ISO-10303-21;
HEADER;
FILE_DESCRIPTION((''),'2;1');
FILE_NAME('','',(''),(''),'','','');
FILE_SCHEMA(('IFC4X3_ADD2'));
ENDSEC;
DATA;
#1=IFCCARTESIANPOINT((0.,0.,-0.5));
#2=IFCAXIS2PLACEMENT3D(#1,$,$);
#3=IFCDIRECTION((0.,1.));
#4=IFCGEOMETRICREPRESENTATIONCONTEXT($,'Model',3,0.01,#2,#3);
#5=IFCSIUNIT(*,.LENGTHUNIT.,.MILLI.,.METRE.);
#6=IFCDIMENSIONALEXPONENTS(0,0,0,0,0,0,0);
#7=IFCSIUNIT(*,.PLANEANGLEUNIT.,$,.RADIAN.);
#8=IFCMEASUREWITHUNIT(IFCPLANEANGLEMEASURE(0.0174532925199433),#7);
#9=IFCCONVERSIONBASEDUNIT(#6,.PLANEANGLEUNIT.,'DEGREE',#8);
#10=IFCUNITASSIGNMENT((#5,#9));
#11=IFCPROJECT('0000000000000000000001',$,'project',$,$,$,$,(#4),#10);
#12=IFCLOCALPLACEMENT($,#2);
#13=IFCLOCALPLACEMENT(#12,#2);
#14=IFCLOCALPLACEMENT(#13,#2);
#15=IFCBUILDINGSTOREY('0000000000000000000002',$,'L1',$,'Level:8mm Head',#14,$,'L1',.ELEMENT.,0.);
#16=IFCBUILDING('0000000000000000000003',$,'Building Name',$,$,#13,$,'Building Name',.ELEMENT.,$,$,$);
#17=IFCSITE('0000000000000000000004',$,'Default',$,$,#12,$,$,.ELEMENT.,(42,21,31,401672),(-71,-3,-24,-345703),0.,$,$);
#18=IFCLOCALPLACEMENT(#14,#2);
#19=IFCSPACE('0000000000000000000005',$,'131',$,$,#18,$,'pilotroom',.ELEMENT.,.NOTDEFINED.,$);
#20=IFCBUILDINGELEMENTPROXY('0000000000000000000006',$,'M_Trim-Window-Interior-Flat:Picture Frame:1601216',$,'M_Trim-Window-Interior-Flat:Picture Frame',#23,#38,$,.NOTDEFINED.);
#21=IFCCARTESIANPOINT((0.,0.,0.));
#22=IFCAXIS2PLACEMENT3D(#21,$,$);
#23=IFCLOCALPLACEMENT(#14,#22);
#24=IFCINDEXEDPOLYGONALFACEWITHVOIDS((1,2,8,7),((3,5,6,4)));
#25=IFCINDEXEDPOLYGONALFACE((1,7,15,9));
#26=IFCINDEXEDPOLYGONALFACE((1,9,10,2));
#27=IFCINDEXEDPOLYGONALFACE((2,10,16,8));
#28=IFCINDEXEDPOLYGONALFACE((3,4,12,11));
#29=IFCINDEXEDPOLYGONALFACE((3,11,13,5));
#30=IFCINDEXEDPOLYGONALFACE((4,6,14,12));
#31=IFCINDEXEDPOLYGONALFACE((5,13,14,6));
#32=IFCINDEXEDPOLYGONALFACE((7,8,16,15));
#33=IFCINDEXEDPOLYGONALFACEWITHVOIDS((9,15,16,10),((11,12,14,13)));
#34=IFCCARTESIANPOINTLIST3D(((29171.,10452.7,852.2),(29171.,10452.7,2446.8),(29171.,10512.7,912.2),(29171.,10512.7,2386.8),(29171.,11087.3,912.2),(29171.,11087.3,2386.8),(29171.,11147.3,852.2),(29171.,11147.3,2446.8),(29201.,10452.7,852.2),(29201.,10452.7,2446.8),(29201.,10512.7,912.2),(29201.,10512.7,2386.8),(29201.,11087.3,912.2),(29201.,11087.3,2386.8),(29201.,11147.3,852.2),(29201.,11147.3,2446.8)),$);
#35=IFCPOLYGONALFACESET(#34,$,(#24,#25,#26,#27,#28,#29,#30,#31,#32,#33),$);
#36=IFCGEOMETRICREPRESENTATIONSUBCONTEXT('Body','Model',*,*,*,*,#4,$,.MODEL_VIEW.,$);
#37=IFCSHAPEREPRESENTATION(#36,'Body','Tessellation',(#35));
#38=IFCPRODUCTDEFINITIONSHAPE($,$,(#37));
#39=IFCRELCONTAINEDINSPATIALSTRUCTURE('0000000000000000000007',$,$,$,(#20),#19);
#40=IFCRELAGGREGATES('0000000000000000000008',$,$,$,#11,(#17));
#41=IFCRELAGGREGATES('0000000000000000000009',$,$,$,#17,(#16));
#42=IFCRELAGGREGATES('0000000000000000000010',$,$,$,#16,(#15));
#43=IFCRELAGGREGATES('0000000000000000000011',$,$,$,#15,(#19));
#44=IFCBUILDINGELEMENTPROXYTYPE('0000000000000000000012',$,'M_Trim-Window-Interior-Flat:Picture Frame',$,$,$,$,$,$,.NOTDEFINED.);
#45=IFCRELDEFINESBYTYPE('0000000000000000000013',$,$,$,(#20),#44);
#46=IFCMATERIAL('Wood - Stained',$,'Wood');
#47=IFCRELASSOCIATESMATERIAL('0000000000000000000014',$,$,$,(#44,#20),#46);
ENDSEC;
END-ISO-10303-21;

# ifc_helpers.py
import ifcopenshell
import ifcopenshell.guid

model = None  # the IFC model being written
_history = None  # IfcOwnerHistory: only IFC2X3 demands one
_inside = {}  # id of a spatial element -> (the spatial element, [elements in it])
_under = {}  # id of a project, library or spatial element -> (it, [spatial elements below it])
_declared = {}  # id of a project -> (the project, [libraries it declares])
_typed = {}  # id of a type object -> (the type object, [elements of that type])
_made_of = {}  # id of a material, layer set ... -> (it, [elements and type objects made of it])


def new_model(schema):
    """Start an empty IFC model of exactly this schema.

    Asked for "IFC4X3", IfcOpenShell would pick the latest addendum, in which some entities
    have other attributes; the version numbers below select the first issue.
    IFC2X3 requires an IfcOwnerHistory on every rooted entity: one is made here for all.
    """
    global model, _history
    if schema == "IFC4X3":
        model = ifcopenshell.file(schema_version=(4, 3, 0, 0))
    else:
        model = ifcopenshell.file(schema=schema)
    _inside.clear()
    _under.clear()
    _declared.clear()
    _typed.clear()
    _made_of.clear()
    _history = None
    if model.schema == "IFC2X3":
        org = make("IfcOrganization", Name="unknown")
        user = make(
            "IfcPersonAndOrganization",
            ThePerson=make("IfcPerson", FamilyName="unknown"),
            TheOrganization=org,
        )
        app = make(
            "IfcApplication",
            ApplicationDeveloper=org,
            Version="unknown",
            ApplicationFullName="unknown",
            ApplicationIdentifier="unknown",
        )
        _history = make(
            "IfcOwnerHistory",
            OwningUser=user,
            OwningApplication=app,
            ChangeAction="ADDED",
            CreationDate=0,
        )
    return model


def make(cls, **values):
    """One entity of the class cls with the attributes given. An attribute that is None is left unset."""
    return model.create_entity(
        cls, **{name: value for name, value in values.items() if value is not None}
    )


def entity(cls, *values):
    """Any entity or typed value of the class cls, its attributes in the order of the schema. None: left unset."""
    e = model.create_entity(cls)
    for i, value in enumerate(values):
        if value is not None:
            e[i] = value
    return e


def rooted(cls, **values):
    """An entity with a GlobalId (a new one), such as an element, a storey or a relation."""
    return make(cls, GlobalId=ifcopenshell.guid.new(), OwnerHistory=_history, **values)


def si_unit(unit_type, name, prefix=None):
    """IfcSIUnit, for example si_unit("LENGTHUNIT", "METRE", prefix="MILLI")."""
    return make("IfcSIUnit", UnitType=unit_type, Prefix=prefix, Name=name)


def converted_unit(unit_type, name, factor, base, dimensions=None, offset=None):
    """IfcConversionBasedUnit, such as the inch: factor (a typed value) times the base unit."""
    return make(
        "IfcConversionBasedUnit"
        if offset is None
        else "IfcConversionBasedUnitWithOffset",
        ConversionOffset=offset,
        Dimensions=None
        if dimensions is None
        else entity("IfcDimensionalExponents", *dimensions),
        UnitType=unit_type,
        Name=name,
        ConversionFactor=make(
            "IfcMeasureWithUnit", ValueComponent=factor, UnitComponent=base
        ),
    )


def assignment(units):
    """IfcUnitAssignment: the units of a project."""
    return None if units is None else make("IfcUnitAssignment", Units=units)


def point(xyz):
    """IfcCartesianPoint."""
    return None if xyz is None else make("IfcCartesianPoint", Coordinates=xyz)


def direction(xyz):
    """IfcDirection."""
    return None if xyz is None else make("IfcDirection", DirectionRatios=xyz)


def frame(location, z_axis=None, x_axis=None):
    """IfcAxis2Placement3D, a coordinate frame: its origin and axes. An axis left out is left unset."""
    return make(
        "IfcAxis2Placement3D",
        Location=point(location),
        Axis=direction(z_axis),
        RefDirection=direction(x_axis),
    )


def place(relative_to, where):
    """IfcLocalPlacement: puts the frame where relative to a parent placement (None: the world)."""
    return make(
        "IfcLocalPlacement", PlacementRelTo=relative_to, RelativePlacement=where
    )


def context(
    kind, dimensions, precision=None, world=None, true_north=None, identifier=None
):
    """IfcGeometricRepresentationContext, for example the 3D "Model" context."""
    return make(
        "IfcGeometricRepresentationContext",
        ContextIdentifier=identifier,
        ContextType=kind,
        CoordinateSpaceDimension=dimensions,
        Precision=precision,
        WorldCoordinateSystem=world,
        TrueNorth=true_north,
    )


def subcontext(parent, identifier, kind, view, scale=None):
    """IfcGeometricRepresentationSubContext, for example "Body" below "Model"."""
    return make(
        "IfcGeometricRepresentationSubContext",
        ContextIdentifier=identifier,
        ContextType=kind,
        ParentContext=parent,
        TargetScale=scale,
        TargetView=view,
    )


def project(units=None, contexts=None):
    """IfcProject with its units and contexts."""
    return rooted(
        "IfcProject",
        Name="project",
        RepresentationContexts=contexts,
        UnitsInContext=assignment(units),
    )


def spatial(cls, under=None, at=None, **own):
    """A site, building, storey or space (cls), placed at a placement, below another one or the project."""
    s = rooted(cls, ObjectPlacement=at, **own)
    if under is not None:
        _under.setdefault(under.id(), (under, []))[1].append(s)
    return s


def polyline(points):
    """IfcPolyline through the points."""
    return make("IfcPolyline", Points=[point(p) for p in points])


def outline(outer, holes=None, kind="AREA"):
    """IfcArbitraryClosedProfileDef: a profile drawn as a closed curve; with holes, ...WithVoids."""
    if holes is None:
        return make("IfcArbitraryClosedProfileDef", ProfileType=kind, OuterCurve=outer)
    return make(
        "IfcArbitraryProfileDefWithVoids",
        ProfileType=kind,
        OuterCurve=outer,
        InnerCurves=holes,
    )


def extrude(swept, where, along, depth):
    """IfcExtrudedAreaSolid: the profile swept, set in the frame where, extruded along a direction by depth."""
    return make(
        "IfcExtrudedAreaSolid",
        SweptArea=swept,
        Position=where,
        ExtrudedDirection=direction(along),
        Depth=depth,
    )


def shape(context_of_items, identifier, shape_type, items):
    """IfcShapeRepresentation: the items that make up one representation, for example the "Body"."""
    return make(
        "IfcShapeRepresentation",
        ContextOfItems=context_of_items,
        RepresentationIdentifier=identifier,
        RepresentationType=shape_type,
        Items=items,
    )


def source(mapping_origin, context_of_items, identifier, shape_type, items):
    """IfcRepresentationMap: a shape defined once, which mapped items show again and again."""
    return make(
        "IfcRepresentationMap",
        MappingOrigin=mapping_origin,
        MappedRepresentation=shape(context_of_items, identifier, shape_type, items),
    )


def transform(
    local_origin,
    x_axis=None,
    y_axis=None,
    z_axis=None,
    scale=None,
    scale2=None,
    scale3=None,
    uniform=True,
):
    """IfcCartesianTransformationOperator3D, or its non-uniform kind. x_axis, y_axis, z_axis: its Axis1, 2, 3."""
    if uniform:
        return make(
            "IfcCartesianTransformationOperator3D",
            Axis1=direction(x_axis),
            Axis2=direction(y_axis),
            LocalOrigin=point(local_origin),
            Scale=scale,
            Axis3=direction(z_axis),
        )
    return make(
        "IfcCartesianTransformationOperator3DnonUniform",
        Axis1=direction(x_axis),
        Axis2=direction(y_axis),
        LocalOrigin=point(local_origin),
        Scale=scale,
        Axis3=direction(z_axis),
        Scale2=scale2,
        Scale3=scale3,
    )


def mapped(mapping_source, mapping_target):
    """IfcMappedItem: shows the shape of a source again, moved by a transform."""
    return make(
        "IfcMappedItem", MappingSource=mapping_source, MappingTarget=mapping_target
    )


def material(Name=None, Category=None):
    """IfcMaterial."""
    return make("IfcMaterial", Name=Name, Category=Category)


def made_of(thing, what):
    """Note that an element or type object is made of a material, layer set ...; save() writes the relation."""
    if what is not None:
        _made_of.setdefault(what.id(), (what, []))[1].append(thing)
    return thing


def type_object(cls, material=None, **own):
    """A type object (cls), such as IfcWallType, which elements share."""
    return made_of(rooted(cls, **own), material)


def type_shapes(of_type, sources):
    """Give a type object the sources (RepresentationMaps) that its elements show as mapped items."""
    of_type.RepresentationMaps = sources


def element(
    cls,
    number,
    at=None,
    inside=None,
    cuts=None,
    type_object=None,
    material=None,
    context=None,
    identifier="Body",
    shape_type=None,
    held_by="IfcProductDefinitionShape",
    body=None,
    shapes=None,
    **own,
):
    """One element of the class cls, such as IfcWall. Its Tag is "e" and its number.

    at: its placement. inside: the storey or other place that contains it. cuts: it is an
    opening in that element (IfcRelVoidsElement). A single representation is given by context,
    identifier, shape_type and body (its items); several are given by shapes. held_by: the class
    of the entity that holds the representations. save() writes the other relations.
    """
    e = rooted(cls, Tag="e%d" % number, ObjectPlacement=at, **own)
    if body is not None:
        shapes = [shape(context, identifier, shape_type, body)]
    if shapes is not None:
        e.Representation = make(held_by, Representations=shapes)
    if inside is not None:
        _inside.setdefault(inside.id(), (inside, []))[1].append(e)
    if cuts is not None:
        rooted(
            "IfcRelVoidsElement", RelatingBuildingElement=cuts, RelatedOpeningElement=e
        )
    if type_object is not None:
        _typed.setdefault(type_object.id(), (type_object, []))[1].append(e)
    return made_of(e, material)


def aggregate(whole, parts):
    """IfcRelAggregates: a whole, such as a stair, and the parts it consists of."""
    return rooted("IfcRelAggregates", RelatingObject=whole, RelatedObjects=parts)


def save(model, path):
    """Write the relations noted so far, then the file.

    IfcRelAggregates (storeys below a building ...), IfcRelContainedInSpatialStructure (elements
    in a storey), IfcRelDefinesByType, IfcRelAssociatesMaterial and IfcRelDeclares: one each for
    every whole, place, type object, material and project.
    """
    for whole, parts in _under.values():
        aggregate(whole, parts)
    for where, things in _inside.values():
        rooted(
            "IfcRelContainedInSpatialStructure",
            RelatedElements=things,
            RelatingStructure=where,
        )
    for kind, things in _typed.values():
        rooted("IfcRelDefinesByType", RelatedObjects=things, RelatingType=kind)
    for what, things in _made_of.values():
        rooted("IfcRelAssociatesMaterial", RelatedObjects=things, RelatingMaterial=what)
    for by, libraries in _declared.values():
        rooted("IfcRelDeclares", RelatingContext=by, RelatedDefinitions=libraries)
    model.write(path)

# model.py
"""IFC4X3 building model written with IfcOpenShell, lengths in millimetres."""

from ifc_helpers import new_model, entity, si_unit, converted_unit, direction, frame, place, context, subcontext, project, spatial, polyline, outline, extrude, source, transform, mapped, material, type_object, type_shapes, element, save


model = new_model("IFC4X3")

# Units and contexts
model_context = context("Model", 3, precision=0.01, world=frame((0.0, 0.0, -0.5)), true_north=direction((0.0, 1.0)))
body_context = subcontext(model_context, "Body", "Model", "MODEL_VIEW")
ifc_project = project(units=[si_unit("LENGTHUNIT", "METRE", prefix="MILLI"), converted_unit("PLANEANGLEUNIT", "DEGREE", entity("IfcPlaneAngleMeasure", 0.0174532925199433), si_unit("PLANEANGLEUNIT", "RADIAN"), dimensions=[0, 0, 0, 0, 0, 0, 0])], contexts=[model_context])

# Site, building, storey
site_placement = place(None, frame((0.0, 0.0, -0.5)))
site = spatial("IfcSite", under=ifc_project, at=site_placement, Name="Default", CompositionType="ELEMENT", RefLatitude=(42, 21, 31, 401672), RefLongitude=(-71, -3, -24, -345703), RefElevation=0.0)
building_placement = place(site_placement, frame((0.0, 0.0, -0.5)))
building = spatial("IfcBuilding", under=site, at=building_placement, Name="Building Name", LongName="Building Name", CompositionType="ELEMENT")
storey_placement = place(building_placement, frame((0.0, 0.0, -0.5)))
storey = spatial("IfcBuildingStorey", under=building, at=storey_placement, Name="L1", ObjectType="Level:8mm Head", LongName="L1", CompositionType="ELEMENT", Elevation=0.0)

# Shared definitions
ifc_material_1 = material(Name="Wood - Stained", Category="Wood")

# Shared definitions
space_placement = place(storey_placement, frame((0.0, 0.0, -0.5)))
space = spatial("IfcSpace", under=storey, at=space_placement, Name="131", LongName="pilotroom", CompositionType="ELEMENT", PredefinedType="NOTDEFINED")

# Building element proxy
building_element_proxy_type_1 = type_object("IfcBuildingElementProxyType", Name="M_Trim-Window-Interior-Flat:Picture Frame", PredefinedType="NOTDEFINED", material=ifc_material_1)
shared_shape_1 = source(frame((0.0, 0.0, -0.5)), body_context, "Body", "SweptSolid", [
    extrude(outline(polyline([(-347.3, -797.3), (347.3, -797.3), (347.3, 797.3), (-347.3, 797.3), (-347.3, -797.3)]), holes=[polyline([(-287.3, -737.3), (-287.3, 737.3), (287.3, 737.3), (287.3, -737.3), (-287.3, -737.3)])]), frame((0.0, -750.0, 0.0), z_axis=(0.0, 0.0, 1.0), x_axis=(-1.0, 0.0, 0.0)), (0.0, 0.0, 1.0), 30.0),
])
type_shapes(building_element_proxy_type_1, [shared_shape_1])
proxy_1_placement = place(space_placement, frame((29200.0, 10800.0, 2400.0), z_axis=(-1.0, 0.0, 0.0), x_axis=(0.0, -1.0, 0.0)))
element("IfcBuildingElementProxy", 1, at=proxy_1_placement, inside=space, type_object=building_element_proxy_type_1, material=ifc_material_1, Name="M_Trim-Window-Interior-Flat:Picture Frame:1601216", ObjectType="M_Trim-Window-Interior-Flat:Picture Frame", PredefinedType="NOTDEFINED", context=body_context, shape_type="MappedRepresentation", body=[
    mapped(shared_shape_1, transform((0.0, 0.0, -0.5), scale=1.0)),
])

save(model, "model.ifc")
